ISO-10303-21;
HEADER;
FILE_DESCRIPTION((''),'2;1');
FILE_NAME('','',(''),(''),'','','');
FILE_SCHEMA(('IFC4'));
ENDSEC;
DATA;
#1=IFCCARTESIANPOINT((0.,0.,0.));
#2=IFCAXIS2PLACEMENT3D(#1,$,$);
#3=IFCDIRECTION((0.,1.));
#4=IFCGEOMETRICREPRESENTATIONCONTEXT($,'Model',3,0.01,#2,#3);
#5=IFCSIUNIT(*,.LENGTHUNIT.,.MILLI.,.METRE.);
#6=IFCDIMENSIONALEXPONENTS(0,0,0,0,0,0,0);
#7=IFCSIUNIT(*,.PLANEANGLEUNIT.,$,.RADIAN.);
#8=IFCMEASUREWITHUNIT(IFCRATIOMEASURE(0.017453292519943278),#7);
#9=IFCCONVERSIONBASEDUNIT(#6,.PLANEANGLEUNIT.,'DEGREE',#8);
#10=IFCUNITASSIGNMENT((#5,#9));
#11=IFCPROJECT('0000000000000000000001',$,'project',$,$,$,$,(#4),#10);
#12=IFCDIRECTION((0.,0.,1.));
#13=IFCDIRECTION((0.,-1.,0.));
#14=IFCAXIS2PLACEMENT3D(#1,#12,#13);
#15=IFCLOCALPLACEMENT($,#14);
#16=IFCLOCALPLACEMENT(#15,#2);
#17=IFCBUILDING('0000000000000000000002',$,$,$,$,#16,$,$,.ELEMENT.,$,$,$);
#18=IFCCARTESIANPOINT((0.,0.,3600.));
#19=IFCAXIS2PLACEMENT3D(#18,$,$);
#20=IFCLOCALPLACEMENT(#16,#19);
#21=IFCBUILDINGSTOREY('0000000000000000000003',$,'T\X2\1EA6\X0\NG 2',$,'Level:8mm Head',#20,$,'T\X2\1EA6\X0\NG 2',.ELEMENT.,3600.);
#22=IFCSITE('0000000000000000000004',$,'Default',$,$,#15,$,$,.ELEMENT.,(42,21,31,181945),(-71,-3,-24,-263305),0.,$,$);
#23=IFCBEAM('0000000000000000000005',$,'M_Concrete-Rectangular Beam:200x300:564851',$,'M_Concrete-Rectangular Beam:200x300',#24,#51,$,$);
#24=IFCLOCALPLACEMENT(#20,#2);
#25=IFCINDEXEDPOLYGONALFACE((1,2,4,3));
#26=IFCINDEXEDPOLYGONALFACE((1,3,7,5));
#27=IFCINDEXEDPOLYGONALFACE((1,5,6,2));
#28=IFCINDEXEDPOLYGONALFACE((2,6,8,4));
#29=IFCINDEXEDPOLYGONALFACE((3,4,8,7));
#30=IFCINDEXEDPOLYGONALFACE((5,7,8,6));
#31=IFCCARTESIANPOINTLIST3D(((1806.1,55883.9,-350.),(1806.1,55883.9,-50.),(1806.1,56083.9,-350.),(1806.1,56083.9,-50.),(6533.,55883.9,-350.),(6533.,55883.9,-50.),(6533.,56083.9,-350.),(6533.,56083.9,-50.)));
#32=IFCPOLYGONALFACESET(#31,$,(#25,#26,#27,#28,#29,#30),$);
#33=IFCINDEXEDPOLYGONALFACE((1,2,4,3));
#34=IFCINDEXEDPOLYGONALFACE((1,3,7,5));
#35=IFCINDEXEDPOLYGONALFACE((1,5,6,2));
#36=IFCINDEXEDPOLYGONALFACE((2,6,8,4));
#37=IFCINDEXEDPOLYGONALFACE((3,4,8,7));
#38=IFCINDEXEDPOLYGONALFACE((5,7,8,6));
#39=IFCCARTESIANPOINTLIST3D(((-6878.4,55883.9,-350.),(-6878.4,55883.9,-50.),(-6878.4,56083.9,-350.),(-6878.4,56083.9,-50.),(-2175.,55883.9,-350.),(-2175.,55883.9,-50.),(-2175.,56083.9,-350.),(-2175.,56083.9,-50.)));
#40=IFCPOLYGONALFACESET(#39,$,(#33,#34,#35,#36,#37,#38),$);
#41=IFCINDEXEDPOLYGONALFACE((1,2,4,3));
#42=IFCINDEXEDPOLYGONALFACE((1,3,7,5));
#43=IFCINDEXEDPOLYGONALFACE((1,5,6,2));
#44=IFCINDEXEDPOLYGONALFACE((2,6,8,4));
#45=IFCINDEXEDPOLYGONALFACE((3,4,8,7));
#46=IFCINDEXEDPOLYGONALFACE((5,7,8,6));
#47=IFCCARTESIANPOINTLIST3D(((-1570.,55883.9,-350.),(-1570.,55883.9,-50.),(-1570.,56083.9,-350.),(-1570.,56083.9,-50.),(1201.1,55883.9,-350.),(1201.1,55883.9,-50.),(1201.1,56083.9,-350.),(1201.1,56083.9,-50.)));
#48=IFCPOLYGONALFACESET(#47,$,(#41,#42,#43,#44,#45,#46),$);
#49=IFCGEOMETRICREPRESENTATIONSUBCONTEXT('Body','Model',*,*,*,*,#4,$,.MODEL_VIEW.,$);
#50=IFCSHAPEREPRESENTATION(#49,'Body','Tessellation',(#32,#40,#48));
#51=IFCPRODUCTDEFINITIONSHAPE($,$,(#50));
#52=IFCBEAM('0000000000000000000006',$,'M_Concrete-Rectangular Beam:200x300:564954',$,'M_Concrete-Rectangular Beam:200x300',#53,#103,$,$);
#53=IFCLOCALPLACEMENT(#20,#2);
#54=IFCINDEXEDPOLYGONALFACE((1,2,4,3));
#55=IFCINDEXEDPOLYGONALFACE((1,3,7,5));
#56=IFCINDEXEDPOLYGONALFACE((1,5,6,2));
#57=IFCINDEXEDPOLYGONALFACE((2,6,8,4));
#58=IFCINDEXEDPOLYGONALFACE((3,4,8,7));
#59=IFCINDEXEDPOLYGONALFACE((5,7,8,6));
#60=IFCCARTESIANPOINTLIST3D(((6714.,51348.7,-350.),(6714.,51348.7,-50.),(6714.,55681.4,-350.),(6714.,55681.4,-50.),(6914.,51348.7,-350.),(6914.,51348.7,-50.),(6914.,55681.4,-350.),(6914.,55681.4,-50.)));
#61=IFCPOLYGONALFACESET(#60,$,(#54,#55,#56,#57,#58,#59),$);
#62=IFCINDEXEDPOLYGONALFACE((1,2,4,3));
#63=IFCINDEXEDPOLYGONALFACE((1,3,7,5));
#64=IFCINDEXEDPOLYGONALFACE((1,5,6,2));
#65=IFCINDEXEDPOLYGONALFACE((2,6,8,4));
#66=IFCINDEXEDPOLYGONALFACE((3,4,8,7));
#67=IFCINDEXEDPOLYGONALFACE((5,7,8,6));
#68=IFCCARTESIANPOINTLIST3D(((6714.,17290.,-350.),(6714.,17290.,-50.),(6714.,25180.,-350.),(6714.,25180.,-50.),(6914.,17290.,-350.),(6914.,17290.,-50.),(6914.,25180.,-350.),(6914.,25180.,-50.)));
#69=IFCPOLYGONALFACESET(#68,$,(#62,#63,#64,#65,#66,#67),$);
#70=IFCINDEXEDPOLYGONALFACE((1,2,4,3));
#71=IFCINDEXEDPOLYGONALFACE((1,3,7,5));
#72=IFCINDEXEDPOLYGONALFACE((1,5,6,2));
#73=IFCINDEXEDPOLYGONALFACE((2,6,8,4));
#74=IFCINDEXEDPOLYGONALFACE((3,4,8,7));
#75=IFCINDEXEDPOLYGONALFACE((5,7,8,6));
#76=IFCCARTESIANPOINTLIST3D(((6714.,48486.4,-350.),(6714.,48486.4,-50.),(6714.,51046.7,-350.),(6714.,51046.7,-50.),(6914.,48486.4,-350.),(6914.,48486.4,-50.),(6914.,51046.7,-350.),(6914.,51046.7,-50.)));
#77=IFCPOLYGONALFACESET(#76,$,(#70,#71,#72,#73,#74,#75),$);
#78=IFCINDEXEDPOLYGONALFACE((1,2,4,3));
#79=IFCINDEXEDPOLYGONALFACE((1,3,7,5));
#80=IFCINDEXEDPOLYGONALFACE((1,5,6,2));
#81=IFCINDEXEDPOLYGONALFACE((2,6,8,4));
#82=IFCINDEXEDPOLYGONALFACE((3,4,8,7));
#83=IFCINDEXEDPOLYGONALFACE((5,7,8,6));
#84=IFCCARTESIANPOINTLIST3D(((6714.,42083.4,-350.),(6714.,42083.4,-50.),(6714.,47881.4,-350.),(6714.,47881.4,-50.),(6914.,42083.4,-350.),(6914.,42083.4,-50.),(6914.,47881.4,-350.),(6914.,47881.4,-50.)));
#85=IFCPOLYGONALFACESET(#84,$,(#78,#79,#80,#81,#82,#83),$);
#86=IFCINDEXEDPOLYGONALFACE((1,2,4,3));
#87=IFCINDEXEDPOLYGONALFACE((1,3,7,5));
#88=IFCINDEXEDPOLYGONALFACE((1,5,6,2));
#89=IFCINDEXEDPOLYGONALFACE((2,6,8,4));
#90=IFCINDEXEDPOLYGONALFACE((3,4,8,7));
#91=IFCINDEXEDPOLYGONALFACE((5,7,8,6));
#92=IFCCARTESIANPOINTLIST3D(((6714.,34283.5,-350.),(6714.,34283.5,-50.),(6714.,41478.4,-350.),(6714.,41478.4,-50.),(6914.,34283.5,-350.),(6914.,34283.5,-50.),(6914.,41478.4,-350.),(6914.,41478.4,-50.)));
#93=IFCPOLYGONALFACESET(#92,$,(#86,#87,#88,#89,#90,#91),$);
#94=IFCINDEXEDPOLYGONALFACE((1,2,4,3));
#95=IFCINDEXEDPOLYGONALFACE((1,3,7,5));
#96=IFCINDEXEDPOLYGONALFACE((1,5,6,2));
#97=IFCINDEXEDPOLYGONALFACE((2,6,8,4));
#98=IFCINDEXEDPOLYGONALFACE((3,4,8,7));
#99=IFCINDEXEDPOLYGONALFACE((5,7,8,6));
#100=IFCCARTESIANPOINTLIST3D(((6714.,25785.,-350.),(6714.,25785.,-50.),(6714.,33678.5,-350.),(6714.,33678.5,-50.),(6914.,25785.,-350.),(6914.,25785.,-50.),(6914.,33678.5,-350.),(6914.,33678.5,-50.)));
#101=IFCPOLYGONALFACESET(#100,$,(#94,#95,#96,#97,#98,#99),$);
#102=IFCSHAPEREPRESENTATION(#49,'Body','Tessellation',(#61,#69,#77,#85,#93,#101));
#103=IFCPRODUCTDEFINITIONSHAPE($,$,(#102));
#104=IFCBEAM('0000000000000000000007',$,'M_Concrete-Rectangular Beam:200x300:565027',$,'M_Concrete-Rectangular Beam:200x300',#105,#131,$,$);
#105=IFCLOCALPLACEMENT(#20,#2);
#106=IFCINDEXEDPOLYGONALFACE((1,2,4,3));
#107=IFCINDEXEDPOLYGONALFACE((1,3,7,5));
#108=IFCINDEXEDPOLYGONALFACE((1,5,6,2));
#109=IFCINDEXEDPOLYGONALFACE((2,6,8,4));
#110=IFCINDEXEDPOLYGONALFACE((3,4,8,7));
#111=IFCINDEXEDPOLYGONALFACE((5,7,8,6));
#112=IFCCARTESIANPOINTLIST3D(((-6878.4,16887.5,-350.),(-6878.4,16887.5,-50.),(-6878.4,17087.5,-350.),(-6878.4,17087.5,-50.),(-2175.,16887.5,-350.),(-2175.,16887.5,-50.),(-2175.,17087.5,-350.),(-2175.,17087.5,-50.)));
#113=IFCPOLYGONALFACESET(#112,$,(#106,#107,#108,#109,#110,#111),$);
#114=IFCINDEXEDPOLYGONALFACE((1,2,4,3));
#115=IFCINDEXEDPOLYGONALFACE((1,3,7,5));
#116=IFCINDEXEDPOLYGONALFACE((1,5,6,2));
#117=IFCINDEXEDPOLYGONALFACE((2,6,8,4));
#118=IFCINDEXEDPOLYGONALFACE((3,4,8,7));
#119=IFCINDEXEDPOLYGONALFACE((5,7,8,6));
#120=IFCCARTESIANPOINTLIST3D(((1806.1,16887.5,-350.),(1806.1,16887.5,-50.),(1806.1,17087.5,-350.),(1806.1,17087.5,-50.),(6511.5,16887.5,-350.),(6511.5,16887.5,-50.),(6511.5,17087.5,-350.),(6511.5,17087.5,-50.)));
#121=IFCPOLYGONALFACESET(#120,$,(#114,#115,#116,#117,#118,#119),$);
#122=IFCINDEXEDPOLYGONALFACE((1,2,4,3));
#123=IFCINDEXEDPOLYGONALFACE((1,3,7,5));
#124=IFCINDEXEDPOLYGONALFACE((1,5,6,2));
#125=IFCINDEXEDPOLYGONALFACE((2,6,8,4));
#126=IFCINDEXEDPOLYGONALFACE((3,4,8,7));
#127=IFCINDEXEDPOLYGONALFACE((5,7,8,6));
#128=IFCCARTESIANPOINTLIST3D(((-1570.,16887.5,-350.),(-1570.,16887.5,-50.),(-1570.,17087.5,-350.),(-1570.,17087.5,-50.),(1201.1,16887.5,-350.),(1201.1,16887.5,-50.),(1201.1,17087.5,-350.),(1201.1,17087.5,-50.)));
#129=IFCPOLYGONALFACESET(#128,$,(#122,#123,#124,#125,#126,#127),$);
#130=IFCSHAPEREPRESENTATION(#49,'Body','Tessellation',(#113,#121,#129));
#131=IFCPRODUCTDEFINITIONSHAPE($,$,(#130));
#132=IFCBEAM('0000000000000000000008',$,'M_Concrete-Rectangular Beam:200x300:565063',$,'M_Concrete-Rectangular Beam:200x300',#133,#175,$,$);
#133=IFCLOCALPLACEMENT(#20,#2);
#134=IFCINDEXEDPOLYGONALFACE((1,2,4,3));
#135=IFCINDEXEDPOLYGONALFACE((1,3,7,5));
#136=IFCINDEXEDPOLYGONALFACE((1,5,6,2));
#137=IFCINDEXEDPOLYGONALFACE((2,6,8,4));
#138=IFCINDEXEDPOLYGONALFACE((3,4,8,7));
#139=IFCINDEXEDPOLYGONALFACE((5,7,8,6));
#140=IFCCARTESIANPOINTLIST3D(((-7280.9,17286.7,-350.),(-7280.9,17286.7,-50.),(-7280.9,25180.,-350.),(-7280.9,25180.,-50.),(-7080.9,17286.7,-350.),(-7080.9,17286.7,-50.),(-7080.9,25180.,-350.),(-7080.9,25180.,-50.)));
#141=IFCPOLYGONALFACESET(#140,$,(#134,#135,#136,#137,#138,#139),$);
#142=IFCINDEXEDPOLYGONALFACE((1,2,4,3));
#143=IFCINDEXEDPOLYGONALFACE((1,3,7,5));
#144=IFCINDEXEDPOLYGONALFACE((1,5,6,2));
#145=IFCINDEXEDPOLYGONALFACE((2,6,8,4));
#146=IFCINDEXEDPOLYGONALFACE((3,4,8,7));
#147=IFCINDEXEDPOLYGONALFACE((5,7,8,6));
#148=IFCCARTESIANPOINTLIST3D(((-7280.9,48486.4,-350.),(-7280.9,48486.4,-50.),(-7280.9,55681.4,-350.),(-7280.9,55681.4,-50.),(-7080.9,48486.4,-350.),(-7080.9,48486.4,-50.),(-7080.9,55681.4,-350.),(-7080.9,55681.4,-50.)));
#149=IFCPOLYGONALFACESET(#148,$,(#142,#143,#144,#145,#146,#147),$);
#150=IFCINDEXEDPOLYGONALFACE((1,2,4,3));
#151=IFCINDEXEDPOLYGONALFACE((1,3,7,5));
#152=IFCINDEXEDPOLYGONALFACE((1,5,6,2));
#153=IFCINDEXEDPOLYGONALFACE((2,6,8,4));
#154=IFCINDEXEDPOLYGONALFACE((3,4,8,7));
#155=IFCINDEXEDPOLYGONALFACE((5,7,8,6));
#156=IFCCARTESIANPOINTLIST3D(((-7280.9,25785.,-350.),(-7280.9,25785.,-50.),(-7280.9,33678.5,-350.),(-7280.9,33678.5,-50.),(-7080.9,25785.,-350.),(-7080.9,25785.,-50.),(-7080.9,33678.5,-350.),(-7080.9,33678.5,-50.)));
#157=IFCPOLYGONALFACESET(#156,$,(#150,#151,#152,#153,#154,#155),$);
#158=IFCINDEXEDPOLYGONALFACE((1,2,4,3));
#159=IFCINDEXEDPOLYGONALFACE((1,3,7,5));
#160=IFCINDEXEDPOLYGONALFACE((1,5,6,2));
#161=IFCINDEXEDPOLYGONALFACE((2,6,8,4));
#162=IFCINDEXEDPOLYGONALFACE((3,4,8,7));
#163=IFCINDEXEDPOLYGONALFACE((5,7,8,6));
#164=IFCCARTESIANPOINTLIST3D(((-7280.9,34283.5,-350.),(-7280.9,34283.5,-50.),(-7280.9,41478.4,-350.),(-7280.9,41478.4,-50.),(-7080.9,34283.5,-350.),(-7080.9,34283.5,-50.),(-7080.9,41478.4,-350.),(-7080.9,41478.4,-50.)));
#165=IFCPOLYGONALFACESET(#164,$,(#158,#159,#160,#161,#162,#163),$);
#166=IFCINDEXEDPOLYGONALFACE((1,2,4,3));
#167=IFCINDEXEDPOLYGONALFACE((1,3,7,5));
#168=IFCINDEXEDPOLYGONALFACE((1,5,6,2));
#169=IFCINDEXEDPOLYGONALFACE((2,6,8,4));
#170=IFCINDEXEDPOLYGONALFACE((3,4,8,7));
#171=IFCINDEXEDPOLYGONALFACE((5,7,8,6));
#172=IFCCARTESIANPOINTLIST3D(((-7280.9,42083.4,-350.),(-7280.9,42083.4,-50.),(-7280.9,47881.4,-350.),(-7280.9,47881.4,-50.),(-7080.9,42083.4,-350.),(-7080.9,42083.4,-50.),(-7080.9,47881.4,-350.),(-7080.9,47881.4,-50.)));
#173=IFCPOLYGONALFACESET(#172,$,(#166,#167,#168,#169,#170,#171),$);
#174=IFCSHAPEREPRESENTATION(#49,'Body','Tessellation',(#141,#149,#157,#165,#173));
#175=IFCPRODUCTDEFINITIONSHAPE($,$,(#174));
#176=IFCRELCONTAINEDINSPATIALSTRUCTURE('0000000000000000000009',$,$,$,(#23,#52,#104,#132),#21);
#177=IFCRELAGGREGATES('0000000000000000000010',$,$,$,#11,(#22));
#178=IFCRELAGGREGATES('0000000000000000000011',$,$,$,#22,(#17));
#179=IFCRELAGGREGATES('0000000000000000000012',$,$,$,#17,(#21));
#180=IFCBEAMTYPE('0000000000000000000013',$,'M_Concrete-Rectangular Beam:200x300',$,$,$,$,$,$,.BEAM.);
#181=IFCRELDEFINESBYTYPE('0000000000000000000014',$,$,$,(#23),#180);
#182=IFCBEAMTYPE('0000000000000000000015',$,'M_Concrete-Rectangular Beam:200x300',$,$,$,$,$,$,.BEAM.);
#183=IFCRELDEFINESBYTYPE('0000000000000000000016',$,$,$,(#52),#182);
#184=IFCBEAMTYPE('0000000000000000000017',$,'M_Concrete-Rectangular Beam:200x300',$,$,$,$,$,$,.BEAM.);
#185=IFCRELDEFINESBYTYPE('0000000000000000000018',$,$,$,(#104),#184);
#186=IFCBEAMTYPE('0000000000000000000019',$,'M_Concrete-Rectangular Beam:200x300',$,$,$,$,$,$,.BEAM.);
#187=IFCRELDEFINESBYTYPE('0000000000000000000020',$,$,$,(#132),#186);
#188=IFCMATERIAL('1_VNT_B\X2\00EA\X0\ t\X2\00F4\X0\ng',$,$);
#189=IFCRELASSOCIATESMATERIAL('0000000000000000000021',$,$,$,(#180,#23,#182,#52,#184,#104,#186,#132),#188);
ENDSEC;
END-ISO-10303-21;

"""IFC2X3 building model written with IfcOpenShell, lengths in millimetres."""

from ifc_helpers import new_model, entity, si_unit, converted_unit, direction, frame, frame_2d, origin, origin_2d_with_axis, place, context, subcontext, project, spatial, rectangle, extrude, source, transform, mapped, material, type_object, type_shapes, element, save


model = new_model("IFC2X3")

# Units and contexts
model_context = context("Model", 3, precision=0.01, world=origin(), true_north=direction((0.0, 1.0)))
body_context = subcontext(model_context, "Body", "Model", "MODEL_VIEW")
ifc_project = project(units=[si_unit("LENGTHUNIT", "METRE", prefix="MILLI"), converted_unit("PLANEANGLEUNIT", "DEGREE", entity("IfcRatioMeasure", 0.017453292519943278), si_unit("PLANEANGLEUNIT", "RADIAN"), dimensions=[0, 0, 0, 0, 0, 0, 0])], contexts=[model_context])

# Site, building, storey
site_placement = place(None, frame((0.0, 0.0, 0.0), z_axis=(0.0, 0.0, 1.0), x_axis=(0.0, -1.0, 0.0)))
site = spatial("IfcSite", under=ifc_project, at=site_placement, Name="Default", CompositionType="ELEMENT", RefLatitude=(42, 21, 31, 181945), RefLongitude=(-71, -3, -24, -263305), RefElevation=0.0)
building_placement = place(site_placement, origin())
building = spatial("IfcBuilding", under=site, at=building_placement, CompositionType="ELEMENT")
storey_placement = place(building_placement, frame((0.0, 0.0, 3600.0)))
storey = spatial("IfcBuildingStorey", under=building, at=storey_placement, Name="TẦNG 2", ObjectType="Level:8mm Head", LongName="TẦNG 2", CompositionType="ELEMENT", Elevation=3600.0)

# Beams
ifc_material = material(Name="1_VNT_Bê tông")
beam_type_1 = type_object("IfcBeamType", Name="M_Concrete-Rectangular Beam:200x300", PredefinedType="BEAM", material=ifc_material)
shared_shape_1 = source(origin(), body_context, "Body", "SweptSolid", [
    extrude(rectangle(XDim=300.0, YDim=200.0, at=origin_2d_with_axis()), frame((1806.1, 55983.9, 3400.0), z_axis=(1.0, 0.0, 0.0), x_axis=(0.0, 0.0, -1.0)), (0.0, 0.0, 1.0), 4726.9),
    extrude(rectangle(XDim=300.0, YDim=200.0, at=origin_2d_with_axis()), frame((-6878.4, 55983.9, 3400.0), z_axis=(1.0, 0.0, 0.0), x_axis=(0.0, 0.0, -1.0)), (0.0, 0.0, 1.0), 4703.5),
    extrude(rectangle(XDim=300.0, YDim=200.0, at=frame_2d((0.0, 0.0), x_axis=(1.0, 0.0))), frame((-1570.0, 55983.9, 3400.0), z_axis=(1.0, 0.0, 0.0), x_axis=(0.0, 0.0, -1.0)), (0.0, 0.0, 1.0), 2771.1),
])
type_shapes(beam_type_1, [shared_shape_1])
beam_1_placement = place(storey_placement, frame((0.0, 0.0, -3600.0)))
element("IfcBeam", 1, at=beam_1_placement, inside=storey, type_object=beam_type_1, material=ifc_material, Name="M_Concrete-Rectangular Beam:200x300:564851", ObjectType="M_Concrete-Rectangular Beam:200x300", context=body_context, shape_type="MappedRepresentation", body=[
    mapped(shared_shape_1, transform((0.0, 0.0, 0.0), scale=1.0)),
])
beam_type_2 = type_object("IfcBeamType", Name="M_Concrete-Rectangular Beam:200x300", PredefinedType="BEAM", material=ifc_material)
shared_shape_2 = source(origin(), body_context, "Body", "SweptSolid", [
    extrude(rectangle(XDim=300.0, YDim=200.0, at=frame_2d((0.0, 0.0), x_axis=(0.0, 1.0))), frame((6814.0, 51348.7, 3400.0), z_axis=(0.0, 1.0, 0.0), x_axis=(-1.0, 0.0, 0.0)), (0.0, 0.0, 1.0), 4332.7),
    extrude(rectangle(XDim=300.0, YDim=200.0, at=frame_2d((0.0, 0.0), x_axis=(0.0, 1.0))), frame((6814.0, 17290.0, 3400.0), z_axis=(0.0, 1.0, 0.0), x_axis=(-1.0, 0.0, 0.0)), (0.0, 0.0, 1.0), 7890.0),
    extrude(rectangle(XDim=300.0, YDim=200.0, at=frame_2d((0.0, 0.0), x_axis=(0.0, 1.0))), frame((6814.0, 48486.4, 3400.0), z_axis=(0.0, 1.0, 0.0), x_axis=(-1.0, 0.0, 0.0)), (0.0, 0.0, 1.0), 2560.3),
    extrude(rectangle(XDim=300.0, YDim=200.0, at=frame_2d((0.0, 0.0), x_axis=(0.0, 1.0))), frame((6814.0, 42083.4, 3400.0), z_axis=(0.0, 1.0, 0.0), x_axis=(-1.0, 0.0, 0.0)), (0.0, 0.0, 1.0), 5798.0),
    extrude(rectangle(XDim=300.0, YDim=200.0, at=frame_2d((0.0, 0.0), x_axis=(0.0, 1.0))), frame((6814.0, 34283.5, 3400.0), z_axis=(0.0, 1.0, 0.0), x_axis=(-1.0, 0.0, 0.0)), (0.0, 0.0, 1.0), 7195.0),
    extrude(rectangle(XDim=300.0, YDim=200.0, at=frame_2d((0.0, 0.0), x_axis=(0.0, 1.0))), frame((6814.0, 25785.0, 3400.0), z_axis=(0.0, 1.0, 0.0), x_axis=(-1.0, 0.0, 0.0)), (0.0, 0.0, 1.0), 7893.5),
])
type_shapes(beam_type_2, [shared_shape_2])
beam_2_placement = place(storey_placement, frame((0.0, 0.0, -3600.0)))
element("IfcBeam", 2, at=beam_2_placement, inside=storey, type_object=beam_type_2, material=ifc_material, Name="M_Concrete-Rectangular Beam:200x300:564954", ObjectType="M_Concrete-Rectangular Beam:200x300", context=body_context, shape_type="MappedRepresentation", body=[
    mapped(shared_shape_2, transform((0.0, 0.0, 0.0), scale=1.0)),
])
beam_type_3 = type_object("IfcBeamType", Name="M_Concrete-Rectangular Beam:200x300", PredefinedType="BEAM", material=ifc_material)
shared_shape_3 = source(origin(), body_context, "Body", "SweptSolid", [
    extrude(rectangle(XDim=300.0, YDim=200.0, at=frame_2d((0.0, 0.0), x_axis=(1.0, 0.0))), frame((-2175.0, 16987.5, 3400.0), z_axis=(-1.0, 0.0, 0.0), x_axis=(0.0, 0.0, -1.0)), (0.0, 0.0, 1.0), 4703.5),
    extrude(rectangle(XDim=300.0, YDim=200.0, at=frame_2d((0.0, 0.0), x_axis=(1.0, 0.0))), frame((6511.5, 16987.5, 3400.0), z_axis=(-1.0, 0.0, 0.0), x_axis=(0.0, 0.0, -1.0)), (0.0, 0.0, 1.0), 4705.3),
    extrude(rectangle(XDim=300.0, YDim=200.0, at=frame_2d((0.0, 0.0), x_axis=(1.0, 0.0))), frame((1201.1, 16987.5, 3400.0), z_axis=(-1.0, 0.0, 0.0), x_axis=(0.0, 0.0, -1.0)), (0.0, 0.0, 1.0), 2771.1),
])
type_shapes(beam_type_3, [shared_shape_3])
beam_3_placement = place(storey_placement, frame((0.0, 0.0, -3600.0)))
element("IfcBeam", 3, at=beam_3_placement, inside=storey, type_object=beam_type_3, material=ifc_material, Name="M_Concrete-Rectangular Beam:200x300:565027", ObjectType="M_Concrete-Rectangular Beam:200x300", context=body_context, shape_type="MappedRepresentation", body=[
    mapped(shared_shape_3, transform((0.0, 0.0, 0.0), scale=1.0)),
])
beam_type_4 = type_object("IfcBeamType", Name="M_Concrete-Rectangular Beam:200x300", PredefinedType="BEAM", material=ifc_material)
shared_shape_4 = source(origin(), body_context, "Body", "SweptSolid", [
    extrude(rectangle(XDim=300.0, YDim=200.0, at=frame_2d((0.0, 0.0), x_axis=(0.0, 1.0))), frame((-7180.9, 17286.7, 3400.0), z_axis=(0.0, 1.0, 0.0), x_axis=(-1.0, 0.0, 0.0)), (0.0, 0.0, 1.0), 7893.3),
    extrude(rectangle(XDim=300.0, YDim=200.0, at=frame_2d((0.0, 0.0), x_axis=(0.0, 1.0))), frame((-7180.9, 48486.4, 3400.0), z_axis=(0.0, 1.0, 0.0), x_axis=(-1.0, 0.0, 0.0)), (0.0, 0.0, 1.0), 7195.0),
    extrude(rectangle(XDim=300.0, YDim=200.0, at=frame_2d((0.0, 0.0), x_axis=(0.0, 1.0))), frame((-7180.9, 25785.0, 3400.0), z_axis=(0.0, 1.0, 0.0), x_axis=(-1.0, 0.0, 0.0)), (0.0, 0.0, 1.0), 7893.5),
    extrude(rectangle(XDim=300.0, YDim=200.0, at=frame_2d((0.0, 0.0), x_axis=(0.0, 1.0))), frame((-7180.9, 34283.5, 3400.0), z_axis=(0.0, 1.0, 0.0), x_axis=(-1.0, 0.0, 0.0)), (0.0, 0.0, 1.0), 7195.0),
    extrude(rectangle(XDim=300.0, YDim=200.0, at=frame_2d((0.0, 0.0), x_axis=(0.0, 1.0))), frame((-7180.9, 42083.4, 3400.0), z_axis=(0.0, 1.0, 0.0), x_axis=(-1.0, 0.0, 0.0)), (0.0, 0.0, 1.0), 5798.0),
])
type_shapes(beam_type_4, [shared_shape_4])
beam_4_placement = place(storey_placement, frame((0.0, 0.0, -3600.0)))
element("IfcBeam", 4, at=beam_4_placement, inside=storey, type_object=beam_type_4, material=ifc_material, Name="M_Concrete-Rectangular Beam:200x300:565063", ObjectType="M_Concrete-Rectangular Beam:200x300", context=body_context, shape_type="MappedRepresentation", body=[
    mapped(shared_shape_4, transform((0.0, 0.0, 0.0), scale=1.0)),
])

save(model, "model.ifc")
